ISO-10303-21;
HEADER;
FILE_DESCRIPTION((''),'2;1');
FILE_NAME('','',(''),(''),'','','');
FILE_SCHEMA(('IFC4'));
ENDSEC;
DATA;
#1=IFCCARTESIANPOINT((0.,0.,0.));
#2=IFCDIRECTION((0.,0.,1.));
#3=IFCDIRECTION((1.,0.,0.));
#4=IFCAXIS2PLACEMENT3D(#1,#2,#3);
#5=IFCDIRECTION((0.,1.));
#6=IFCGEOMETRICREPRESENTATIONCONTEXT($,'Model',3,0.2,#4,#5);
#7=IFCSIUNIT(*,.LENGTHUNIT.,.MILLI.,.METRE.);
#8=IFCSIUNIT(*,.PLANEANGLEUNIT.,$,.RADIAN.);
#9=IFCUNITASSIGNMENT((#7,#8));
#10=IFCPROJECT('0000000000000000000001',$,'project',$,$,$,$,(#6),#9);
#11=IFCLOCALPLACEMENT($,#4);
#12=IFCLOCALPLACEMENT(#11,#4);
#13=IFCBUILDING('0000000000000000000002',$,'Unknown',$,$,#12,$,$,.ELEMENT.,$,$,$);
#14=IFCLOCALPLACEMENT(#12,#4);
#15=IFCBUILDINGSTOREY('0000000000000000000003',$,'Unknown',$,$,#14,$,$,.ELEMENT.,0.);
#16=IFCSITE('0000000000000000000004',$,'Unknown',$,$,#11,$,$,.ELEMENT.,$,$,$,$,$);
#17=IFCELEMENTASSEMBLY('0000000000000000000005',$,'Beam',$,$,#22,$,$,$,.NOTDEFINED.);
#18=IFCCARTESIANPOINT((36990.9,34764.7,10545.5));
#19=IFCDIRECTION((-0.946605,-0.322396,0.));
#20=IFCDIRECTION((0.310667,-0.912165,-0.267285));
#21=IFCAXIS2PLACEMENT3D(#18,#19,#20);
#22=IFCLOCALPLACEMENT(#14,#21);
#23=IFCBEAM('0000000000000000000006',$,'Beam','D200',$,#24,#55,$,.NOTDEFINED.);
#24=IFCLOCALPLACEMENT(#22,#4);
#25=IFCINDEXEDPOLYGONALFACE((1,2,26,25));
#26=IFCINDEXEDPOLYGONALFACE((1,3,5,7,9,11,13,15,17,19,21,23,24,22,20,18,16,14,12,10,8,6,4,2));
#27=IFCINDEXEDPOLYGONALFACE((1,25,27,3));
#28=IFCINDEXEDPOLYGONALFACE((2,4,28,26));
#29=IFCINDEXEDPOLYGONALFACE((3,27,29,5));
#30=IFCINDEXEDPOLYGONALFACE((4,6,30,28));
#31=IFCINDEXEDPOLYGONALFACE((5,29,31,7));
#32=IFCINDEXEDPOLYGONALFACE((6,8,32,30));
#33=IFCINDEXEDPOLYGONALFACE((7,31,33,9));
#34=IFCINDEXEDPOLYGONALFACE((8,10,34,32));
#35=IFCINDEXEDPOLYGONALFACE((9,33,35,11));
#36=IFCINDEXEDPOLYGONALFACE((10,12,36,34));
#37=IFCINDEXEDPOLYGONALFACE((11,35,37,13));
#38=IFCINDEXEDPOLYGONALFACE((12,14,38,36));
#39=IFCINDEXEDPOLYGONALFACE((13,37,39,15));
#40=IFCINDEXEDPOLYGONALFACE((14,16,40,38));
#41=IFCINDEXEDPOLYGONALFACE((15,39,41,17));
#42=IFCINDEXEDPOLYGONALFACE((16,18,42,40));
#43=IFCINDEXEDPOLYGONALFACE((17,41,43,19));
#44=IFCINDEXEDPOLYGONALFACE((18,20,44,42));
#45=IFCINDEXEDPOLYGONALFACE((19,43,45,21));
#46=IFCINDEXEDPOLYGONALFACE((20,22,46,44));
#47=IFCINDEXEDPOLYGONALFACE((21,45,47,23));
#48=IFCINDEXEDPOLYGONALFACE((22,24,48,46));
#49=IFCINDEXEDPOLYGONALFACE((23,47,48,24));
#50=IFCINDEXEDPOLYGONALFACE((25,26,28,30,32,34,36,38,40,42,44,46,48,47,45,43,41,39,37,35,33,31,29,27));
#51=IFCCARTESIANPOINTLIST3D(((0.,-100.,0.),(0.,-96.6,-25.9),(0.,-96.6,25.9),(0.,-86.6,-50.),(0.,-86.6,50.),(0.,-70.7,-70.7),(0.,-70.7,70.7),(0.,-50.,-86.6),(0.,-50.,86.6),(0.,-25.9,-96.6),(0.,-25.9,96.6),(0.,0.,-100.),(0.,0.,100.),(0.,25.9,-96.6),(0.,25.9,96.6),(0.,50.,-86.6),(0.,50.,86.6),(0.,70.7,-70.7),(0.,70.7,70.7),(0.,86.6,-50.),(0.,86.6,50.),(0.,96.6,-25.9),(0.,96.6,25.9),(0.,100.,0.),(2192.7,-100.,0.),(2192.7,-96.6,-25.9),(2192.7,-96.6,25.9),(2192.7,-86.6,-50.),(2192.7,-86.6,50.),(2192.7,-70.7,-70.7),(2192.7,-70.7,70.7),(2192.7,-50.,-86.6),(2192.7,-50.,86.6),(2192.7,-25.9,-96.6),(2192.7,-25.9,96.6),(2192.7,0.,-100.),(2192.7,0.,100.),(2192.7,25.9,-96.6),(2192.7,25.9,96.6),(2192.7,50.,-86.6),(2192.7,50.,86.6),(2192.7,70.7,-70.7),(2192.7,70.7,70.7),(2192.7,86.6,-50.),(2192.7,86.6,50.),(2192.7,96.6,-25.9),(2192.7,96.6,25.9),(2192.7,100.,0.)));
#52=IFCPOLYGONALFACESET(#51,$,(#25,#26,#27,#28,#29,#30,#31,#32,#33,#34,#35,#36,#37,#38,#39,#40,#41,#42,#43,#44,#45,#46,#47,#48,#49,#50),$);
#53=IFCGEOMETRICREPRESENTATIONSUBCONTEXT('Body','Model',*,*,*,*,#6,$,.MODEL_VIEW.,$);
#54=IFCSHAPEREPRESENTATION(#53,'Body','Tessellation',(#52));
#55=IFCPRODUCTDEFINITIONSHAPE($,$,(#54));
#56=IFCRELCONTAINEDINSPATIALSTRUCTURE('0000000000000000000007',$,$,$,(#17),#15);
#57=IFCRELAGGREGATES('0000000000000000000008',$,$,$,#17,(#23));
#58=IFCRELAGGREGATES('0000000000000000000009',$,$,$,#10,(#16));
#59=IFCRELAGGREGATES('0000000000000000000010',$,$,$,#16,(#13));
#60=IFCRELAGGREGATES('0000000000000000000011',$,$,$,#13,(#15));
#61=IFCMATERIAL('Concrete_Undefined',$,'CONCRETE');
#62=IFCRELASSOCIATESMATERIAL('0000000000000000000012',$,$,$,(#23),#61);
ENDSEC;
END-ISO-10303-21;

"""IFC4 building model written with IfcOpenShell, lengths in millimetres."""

from ifc_helpers import new_model, si_unit, direction, frame, origin_with_axes, place, context, subcontext, project, spatial, line, indexed_curve, outline, extrude, material, element, aggregate, save


model = new_model("IFC4")

# Units and contexts
model_context = context("Model", 3, precision=0.2, world=origin_with_axes(), true_north=direction((0.0, 1.0)))
body_context = subcontext(model_context, "Body", "Model", "MODEL_VIEW")
ifc_project = project(units=[si_unit("LENGTHUNIT", "METRE", prefix="MILLI"), si_unit("PLANEANGLEUNIT", "RADIAN")], contexts=[model_context])

# Site, building, storey
site_placement = place(None, origin_with_axes())
site = spatial("IfcSite", under=ifc_project, at=site_placement, Name="Unknown", CompositionType="ELEMENT")
building_placement = place(site_placement, origin_with_axes())
building = spatial("IfcBuilding", under=site, at=building_placement, Name="Unknown", CompositionType="ELEMENT")
storey_placement = place(building_placement, origin_with_axes())
storey = spatial("IfcBuildingStorey", under=building, at=storey_placement, Name="Unknown", CompositionType="ELEMENT", Elevation=0.0)

# Shared definitions
ifc_material = material(Name="Concrete_Undefined", Category="CONCRETE")

# Element assembly, beam
assembly_1_placement = place(storey_placement, frame((36990.9, 34764.7, 10545.5), z_axis=(-0.946605, -0.322396, 0.0), x_axis=(0.310667, -0.912165, -0.267285)))
assembly_1 = element("IfcElementAssembly", 1, at=assembly_1_placement, inside=storey, Name="Beam", PredefinedType="NOTDEFINED")
beam_1_placement = place(assembly_1_placement, origin_with_axes())
beam_1 = element("IfcBeam", 2, at=beam_1_placement, material=ifc_material, Name="Beam", Description="D200", PredefinedType="NOTDEFINED", context=body_context, shape_type="SolidModel", body=[
    extrude(outline(indexed_curve([(100.0, 0.0), (96.6, 25.9), (86.6, 50.0), (70.7, 70.7), (50.0, 86.6), (25.9, 96.6), (0.0, 100.0), (-25.9, 96.6), (-50.0, 86.6), (-70.7, 70.7), (-86.6, 50.0), (-96.6, 25.9), (-100.0, 0.0), (-96.6, -25.9), (-86.6, -50.0), (-70.7, -70.7), (-50.0, -86.6), (-25.9, -96.6), (0.0, -100.0), (25.9, -96.6), (50.0, -86.6), (70.7, -70.7), (86.6, -50.0), (96.6, -25.9)], segments=[line(1, 2, 3, 4, 5, 6, 7, 8, 9, 10, 11, 12, 13, 14, 15, 16, 17, 18, 19, 20, 21, 22, 23, 24, 1)])), frame((0.0, 0.0, 0.0), z_axis=(-1.0, 0.0, 0.0), x_axis=(0.0, 0.0, 1.0)), (0.0, 0.0, -1.0), 2192.7),
])
aggregate(assembly_1, [beam_1])

save(model, "model.ifc")
